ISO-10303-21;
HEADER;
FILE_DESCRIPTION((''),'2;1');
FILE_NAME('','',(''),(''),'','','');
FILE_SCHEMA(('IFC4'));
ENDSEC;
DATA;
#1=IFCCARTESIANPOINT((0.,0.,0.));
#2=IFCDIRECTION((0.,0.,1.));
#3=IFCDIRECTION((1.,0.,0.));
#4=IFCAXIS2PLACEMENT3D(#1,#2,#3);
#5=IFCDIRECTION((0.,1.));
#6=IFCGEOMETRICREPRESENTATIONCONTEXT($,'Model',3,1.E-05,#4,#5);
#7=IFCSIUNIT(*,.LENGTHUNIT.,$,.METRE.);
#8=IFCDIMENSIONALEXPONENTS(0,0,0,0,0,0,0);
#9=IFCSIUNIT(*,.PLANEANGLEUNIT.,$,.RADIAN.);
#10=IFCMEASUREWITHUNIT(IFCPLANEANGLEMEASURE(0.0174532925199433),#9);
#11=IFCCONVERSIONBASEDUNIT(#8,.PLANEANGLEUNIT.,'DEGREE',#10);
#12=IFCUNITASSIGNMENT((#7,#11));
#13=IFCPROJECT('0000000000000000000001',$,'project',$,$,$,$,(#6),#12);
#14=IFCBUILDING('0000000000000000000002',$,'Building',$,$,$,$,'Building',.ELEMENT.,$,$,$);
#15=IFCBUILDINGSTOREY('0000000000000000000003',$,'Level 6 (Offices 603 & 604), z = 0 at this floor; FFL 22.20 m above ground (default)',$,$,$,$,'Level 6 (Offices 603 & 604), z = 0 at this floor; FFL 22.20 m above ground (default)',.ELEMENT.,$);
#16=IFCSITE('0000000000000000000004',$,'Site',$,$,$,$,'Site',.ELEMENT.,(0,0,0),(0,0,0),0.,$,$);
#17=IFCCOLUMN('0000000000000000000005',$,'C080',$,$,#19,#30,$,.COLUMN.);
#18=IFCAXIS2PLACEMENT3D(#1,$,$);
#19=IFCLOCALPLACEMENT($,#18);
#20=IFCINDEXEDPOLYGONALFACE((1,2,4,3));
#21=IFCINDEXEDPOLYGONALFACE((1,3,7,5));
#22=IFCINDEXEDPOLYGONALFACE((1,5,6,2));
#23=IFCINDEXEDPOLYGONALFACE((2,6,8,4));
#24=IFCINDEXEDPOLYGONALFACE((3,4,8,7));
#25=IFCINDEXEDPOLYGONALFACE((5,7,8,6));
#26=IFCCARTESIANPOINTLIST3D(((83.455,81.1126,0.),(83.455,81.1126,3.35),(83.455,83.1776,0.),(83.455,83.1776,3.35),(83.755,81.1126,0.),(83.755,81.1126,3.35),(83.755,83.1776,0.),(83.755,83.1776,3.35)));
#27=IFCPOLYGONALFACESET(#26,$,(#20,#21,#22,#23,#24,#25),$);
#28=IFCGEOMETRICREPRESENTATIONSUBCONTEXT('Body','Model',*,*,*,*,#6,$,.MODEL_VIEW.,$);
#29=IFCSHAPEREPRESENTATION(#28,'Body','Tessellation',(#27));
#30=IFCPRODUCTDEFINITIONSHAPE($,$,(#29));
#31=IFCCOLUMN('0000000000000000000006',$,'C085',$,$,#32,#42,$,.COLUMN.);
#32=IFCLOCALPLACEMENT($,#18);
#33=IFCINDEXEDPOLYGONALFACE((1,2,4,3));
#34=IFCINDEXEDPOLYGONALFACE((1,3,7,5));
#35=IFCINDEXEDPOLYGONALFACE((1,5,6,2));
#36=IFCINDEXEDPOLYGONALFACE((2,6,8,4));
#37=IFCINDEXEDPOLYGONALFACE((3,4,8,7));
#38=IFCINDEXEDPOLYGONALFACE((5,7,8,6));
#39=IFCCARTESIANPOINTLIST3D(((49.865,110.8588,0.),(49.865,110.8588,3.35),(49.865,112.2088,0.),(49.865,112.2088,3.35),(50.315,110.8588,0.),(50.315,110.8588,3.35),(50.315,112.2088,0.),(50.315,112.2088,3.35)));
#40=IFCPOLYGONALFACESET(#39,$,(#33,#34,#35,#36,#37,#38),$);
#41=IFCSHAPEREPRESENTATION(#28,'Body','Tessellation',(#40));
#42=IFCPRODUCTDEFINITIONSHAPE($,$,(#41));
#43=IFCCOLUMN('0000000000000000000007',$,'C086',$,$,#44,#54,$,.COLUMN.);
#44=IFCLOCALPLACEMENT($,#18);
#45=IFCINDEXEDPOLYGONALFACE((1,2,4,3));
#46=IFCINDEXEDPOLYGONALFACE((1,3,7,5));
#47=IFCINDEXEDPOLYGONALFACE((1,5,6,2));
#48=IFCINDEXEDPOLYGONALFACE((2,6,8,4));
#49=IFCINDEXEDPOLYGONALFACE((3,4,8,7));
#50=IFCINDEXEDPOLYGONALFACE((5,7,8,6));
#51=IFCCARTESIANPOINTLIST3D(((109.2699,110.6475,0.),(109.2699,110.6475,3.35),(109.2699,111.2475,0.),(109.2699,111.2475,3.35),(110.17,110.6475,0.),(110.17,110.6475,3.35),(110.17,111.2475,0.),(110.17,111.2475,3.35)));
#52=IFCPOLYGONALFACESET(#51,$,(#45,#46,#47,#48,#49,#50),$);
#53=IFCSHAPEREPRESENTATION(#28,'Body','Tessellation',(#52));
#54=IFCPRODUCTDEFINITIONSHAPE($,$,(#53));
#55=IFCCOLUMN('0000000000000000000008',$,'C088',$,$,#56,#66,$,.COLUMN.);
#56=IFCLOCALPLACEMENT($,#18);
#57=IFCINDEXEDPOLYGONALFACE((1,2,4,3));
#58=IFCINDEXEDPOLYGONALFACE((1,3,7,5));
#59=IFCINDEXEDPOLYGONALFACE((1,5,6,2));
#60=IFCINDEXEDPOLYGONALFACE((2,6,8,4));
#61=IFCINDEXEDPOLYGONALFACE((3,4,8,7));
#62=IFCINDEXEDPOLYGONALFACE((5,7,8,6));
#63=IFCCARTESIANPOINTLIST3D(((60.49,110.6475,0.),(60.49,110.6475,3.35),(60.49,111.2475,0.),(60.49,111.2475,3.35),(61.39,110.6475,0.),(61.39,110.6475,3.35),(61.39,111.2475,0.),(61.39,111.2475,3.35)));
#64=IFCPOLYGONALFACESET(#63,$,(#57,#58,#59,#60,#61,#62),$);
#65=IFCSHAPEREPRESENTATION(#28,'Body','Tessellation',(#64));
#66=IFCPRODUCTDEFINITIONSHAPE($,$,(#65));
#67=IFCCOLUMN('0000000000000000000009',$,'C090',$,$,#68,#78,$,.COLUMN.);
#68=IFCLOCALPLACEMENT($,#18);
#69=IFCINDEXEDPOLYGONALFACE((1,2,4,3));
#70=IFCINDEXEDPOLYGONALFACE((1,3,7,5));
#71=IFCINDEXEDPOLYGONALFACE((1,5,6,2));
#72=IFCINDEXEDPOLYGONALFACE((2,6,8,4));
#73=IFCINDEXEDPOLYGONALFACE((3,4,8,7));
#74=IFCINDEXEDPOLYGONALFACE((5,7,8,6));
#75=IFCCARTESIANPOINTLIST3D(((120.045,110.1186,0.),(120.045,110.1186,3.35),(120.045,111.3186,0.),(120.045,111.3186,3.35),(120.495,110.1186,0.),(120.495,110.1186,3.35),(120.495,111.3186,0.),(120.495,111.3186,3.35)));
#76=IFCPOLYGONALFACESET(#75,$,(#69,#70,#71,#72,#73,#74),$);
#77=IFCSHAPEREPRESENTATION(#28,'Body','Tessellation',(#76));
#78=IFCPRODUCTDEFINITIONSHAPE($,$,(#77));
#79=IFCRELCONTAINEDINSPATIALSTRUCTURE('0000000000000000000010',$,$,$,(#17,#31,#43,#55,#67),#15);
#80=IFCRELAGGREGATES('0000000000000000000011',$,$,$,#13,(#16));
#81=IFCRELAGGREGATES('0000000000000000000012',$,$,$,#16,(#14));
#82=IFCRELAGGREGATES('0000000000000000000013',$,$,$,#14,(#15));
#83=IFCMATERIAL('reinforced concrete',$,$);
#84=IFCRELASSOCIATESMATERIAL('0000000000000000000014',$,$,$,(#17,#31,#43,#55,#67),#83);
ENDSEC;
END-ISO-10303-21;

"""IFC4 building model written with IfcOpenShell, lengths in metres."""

from ifc_helpers import new_model, entity, si_unit, converted_unit, direction, frame, frame_2d, origin_with_axes, place, context, subcontext, project, spatial, rectangle, extrude, material, element, save


model = new_model("IFC4")

# Units and contexts
model_context = context("Model", 3, precision=1e-05, world=origin_with_axes(), true_north=direction((0.0, 1.0)))
body_context = subcontext(model_context, "Body", "Model", "MODEL_VIEW")
ifc_project = project(units=[si_unit("LENGTHUNIT", "METRE"), converted_unit("PLANEANGLEUNIT", "DEGREE", entity("IfcPlaneAngleMeasure", 0.0174532925199433), si_unit("PLANEANGLEUNIT", "RADIAN"), dimensions=[0, 0, 0, 0, 0, 0, 0])], contexts=[model_context])

# Site, building, storey
site = spatial("IfcSite", under=ifc_project, Name="Site", LongName="Site", CompositionType="ELEMENT", RefLatitude=(0, 0, 0), RefLongitude=(0, 0, 0), RefElevation=0.0)
building = spatial("IfcBuilding", under=site, Name="Building", LongName="Building", CompositionType="ELEMENT")
storey = spatial("IfcBuildingStorey", under=building, Name="Level 6 (Offices 603 & 604), z = 0 at this floor; FFL 22.20 m above ground (default)", LongName="Level 6 (Offices 603 & 604), z = 0 at this floor; FFL 22.20 m above ground (default)", CompositionType="ELEMENT")

# Columns
ifc_material = material(Name="reinforced concrete")
placement = place(None, origin_with_axes())
element("IfcColumn", 1, at=placement, inside=storey, material=ifc_material, Name="C080", PredefinedType="COLUMN", context=body_context, shape_type="SweptSolid", body=[
    extrude(rectangle(XDim=2.065, YDim=0.3, at=frame_2d((0.0, 0.0), x_axis=(0.0, -1.0))), frame((83.605, 82.1451, 0.0), z_axis=(0.0, 0.0, 1.0), x_axis=(1.0, 0.0, 0.0)), (0.0, 0.0, 1.0), 3.35),
])
element("IfcColumn", 2, at=placement, inside=storey, material=ifc_material, Name="C085", PredefinedType="COLUMN", context=body_context, shape_type="SweptSolid", body=[
    extrude(rectangle(XDim=0.45, YDim=1.35, at=frame_2d((0.0, 0.0), x_axis=(-1.0, 0.0))), frame((50.09, 111.5338, 0.0), z_axis=(0.0, 0.0, 1.0), x_axis=(1.0, 0.0, 0.0)), (0.0, 0.0, 1.0), 3.35),
])
element("IfcColumn", 3, at=placement, inside=storey, material=ifc_material, Name="C086", PredefinedType="COLUMN", context=body_context, shape_type="SweptSolid", body=[
    extrude(rectangle(XDim=0.9001, YDim=0.6, at=frame_2d((0.0, 0.0), x_axis=(-1.0, 0.0))), frame((109.7199, 110.9475, 0.0), z_axis=(0.0, 0.0, 1.0), x_axis=(1.0, 0.0, 0.0)), (0.0, 0.0, 1.0), 3.35),
])
element("IfcColumn", 4, at=placement, inside=storey, material=ifc_material, Name="C088", PredefinedType="COLUMN", context=body_context, shape_type="SweptSolid", body=[
    extrude(rectangle(XDim=0.9, YDim=0.6, at=frame_2d((0.0, 0.0), x_axis=(-1.0, 0.0))), frame((60.94, 110.9475, 0.0), z_axis=(0.0, 0.0, 1.0), x_axis=(1.0, 0.0, 0.0)), (0.0, 0.0, 1.0), 3.35),
])
element("IfcColumn", 5, at=placement, inside=storey, material=ifc_material, Name="C090", PredefinedType="COLUMN", context=body_context, shape_type="SweptSolid", body=[
    extrude(rectangle(XDim=1.2, YDim=0.45, at=frame_2d((0.0, 0.0), x_axis=(0.0, 1.0))), frame((120.27, 110.7186, 0.0), z_axis=(0.0, 0.0, 1.0), x_axis=(1.0, 0.0, 0.0)), (0.0, 0.0, 1.0), 3.35),
])

save(model, "model.ifc")
